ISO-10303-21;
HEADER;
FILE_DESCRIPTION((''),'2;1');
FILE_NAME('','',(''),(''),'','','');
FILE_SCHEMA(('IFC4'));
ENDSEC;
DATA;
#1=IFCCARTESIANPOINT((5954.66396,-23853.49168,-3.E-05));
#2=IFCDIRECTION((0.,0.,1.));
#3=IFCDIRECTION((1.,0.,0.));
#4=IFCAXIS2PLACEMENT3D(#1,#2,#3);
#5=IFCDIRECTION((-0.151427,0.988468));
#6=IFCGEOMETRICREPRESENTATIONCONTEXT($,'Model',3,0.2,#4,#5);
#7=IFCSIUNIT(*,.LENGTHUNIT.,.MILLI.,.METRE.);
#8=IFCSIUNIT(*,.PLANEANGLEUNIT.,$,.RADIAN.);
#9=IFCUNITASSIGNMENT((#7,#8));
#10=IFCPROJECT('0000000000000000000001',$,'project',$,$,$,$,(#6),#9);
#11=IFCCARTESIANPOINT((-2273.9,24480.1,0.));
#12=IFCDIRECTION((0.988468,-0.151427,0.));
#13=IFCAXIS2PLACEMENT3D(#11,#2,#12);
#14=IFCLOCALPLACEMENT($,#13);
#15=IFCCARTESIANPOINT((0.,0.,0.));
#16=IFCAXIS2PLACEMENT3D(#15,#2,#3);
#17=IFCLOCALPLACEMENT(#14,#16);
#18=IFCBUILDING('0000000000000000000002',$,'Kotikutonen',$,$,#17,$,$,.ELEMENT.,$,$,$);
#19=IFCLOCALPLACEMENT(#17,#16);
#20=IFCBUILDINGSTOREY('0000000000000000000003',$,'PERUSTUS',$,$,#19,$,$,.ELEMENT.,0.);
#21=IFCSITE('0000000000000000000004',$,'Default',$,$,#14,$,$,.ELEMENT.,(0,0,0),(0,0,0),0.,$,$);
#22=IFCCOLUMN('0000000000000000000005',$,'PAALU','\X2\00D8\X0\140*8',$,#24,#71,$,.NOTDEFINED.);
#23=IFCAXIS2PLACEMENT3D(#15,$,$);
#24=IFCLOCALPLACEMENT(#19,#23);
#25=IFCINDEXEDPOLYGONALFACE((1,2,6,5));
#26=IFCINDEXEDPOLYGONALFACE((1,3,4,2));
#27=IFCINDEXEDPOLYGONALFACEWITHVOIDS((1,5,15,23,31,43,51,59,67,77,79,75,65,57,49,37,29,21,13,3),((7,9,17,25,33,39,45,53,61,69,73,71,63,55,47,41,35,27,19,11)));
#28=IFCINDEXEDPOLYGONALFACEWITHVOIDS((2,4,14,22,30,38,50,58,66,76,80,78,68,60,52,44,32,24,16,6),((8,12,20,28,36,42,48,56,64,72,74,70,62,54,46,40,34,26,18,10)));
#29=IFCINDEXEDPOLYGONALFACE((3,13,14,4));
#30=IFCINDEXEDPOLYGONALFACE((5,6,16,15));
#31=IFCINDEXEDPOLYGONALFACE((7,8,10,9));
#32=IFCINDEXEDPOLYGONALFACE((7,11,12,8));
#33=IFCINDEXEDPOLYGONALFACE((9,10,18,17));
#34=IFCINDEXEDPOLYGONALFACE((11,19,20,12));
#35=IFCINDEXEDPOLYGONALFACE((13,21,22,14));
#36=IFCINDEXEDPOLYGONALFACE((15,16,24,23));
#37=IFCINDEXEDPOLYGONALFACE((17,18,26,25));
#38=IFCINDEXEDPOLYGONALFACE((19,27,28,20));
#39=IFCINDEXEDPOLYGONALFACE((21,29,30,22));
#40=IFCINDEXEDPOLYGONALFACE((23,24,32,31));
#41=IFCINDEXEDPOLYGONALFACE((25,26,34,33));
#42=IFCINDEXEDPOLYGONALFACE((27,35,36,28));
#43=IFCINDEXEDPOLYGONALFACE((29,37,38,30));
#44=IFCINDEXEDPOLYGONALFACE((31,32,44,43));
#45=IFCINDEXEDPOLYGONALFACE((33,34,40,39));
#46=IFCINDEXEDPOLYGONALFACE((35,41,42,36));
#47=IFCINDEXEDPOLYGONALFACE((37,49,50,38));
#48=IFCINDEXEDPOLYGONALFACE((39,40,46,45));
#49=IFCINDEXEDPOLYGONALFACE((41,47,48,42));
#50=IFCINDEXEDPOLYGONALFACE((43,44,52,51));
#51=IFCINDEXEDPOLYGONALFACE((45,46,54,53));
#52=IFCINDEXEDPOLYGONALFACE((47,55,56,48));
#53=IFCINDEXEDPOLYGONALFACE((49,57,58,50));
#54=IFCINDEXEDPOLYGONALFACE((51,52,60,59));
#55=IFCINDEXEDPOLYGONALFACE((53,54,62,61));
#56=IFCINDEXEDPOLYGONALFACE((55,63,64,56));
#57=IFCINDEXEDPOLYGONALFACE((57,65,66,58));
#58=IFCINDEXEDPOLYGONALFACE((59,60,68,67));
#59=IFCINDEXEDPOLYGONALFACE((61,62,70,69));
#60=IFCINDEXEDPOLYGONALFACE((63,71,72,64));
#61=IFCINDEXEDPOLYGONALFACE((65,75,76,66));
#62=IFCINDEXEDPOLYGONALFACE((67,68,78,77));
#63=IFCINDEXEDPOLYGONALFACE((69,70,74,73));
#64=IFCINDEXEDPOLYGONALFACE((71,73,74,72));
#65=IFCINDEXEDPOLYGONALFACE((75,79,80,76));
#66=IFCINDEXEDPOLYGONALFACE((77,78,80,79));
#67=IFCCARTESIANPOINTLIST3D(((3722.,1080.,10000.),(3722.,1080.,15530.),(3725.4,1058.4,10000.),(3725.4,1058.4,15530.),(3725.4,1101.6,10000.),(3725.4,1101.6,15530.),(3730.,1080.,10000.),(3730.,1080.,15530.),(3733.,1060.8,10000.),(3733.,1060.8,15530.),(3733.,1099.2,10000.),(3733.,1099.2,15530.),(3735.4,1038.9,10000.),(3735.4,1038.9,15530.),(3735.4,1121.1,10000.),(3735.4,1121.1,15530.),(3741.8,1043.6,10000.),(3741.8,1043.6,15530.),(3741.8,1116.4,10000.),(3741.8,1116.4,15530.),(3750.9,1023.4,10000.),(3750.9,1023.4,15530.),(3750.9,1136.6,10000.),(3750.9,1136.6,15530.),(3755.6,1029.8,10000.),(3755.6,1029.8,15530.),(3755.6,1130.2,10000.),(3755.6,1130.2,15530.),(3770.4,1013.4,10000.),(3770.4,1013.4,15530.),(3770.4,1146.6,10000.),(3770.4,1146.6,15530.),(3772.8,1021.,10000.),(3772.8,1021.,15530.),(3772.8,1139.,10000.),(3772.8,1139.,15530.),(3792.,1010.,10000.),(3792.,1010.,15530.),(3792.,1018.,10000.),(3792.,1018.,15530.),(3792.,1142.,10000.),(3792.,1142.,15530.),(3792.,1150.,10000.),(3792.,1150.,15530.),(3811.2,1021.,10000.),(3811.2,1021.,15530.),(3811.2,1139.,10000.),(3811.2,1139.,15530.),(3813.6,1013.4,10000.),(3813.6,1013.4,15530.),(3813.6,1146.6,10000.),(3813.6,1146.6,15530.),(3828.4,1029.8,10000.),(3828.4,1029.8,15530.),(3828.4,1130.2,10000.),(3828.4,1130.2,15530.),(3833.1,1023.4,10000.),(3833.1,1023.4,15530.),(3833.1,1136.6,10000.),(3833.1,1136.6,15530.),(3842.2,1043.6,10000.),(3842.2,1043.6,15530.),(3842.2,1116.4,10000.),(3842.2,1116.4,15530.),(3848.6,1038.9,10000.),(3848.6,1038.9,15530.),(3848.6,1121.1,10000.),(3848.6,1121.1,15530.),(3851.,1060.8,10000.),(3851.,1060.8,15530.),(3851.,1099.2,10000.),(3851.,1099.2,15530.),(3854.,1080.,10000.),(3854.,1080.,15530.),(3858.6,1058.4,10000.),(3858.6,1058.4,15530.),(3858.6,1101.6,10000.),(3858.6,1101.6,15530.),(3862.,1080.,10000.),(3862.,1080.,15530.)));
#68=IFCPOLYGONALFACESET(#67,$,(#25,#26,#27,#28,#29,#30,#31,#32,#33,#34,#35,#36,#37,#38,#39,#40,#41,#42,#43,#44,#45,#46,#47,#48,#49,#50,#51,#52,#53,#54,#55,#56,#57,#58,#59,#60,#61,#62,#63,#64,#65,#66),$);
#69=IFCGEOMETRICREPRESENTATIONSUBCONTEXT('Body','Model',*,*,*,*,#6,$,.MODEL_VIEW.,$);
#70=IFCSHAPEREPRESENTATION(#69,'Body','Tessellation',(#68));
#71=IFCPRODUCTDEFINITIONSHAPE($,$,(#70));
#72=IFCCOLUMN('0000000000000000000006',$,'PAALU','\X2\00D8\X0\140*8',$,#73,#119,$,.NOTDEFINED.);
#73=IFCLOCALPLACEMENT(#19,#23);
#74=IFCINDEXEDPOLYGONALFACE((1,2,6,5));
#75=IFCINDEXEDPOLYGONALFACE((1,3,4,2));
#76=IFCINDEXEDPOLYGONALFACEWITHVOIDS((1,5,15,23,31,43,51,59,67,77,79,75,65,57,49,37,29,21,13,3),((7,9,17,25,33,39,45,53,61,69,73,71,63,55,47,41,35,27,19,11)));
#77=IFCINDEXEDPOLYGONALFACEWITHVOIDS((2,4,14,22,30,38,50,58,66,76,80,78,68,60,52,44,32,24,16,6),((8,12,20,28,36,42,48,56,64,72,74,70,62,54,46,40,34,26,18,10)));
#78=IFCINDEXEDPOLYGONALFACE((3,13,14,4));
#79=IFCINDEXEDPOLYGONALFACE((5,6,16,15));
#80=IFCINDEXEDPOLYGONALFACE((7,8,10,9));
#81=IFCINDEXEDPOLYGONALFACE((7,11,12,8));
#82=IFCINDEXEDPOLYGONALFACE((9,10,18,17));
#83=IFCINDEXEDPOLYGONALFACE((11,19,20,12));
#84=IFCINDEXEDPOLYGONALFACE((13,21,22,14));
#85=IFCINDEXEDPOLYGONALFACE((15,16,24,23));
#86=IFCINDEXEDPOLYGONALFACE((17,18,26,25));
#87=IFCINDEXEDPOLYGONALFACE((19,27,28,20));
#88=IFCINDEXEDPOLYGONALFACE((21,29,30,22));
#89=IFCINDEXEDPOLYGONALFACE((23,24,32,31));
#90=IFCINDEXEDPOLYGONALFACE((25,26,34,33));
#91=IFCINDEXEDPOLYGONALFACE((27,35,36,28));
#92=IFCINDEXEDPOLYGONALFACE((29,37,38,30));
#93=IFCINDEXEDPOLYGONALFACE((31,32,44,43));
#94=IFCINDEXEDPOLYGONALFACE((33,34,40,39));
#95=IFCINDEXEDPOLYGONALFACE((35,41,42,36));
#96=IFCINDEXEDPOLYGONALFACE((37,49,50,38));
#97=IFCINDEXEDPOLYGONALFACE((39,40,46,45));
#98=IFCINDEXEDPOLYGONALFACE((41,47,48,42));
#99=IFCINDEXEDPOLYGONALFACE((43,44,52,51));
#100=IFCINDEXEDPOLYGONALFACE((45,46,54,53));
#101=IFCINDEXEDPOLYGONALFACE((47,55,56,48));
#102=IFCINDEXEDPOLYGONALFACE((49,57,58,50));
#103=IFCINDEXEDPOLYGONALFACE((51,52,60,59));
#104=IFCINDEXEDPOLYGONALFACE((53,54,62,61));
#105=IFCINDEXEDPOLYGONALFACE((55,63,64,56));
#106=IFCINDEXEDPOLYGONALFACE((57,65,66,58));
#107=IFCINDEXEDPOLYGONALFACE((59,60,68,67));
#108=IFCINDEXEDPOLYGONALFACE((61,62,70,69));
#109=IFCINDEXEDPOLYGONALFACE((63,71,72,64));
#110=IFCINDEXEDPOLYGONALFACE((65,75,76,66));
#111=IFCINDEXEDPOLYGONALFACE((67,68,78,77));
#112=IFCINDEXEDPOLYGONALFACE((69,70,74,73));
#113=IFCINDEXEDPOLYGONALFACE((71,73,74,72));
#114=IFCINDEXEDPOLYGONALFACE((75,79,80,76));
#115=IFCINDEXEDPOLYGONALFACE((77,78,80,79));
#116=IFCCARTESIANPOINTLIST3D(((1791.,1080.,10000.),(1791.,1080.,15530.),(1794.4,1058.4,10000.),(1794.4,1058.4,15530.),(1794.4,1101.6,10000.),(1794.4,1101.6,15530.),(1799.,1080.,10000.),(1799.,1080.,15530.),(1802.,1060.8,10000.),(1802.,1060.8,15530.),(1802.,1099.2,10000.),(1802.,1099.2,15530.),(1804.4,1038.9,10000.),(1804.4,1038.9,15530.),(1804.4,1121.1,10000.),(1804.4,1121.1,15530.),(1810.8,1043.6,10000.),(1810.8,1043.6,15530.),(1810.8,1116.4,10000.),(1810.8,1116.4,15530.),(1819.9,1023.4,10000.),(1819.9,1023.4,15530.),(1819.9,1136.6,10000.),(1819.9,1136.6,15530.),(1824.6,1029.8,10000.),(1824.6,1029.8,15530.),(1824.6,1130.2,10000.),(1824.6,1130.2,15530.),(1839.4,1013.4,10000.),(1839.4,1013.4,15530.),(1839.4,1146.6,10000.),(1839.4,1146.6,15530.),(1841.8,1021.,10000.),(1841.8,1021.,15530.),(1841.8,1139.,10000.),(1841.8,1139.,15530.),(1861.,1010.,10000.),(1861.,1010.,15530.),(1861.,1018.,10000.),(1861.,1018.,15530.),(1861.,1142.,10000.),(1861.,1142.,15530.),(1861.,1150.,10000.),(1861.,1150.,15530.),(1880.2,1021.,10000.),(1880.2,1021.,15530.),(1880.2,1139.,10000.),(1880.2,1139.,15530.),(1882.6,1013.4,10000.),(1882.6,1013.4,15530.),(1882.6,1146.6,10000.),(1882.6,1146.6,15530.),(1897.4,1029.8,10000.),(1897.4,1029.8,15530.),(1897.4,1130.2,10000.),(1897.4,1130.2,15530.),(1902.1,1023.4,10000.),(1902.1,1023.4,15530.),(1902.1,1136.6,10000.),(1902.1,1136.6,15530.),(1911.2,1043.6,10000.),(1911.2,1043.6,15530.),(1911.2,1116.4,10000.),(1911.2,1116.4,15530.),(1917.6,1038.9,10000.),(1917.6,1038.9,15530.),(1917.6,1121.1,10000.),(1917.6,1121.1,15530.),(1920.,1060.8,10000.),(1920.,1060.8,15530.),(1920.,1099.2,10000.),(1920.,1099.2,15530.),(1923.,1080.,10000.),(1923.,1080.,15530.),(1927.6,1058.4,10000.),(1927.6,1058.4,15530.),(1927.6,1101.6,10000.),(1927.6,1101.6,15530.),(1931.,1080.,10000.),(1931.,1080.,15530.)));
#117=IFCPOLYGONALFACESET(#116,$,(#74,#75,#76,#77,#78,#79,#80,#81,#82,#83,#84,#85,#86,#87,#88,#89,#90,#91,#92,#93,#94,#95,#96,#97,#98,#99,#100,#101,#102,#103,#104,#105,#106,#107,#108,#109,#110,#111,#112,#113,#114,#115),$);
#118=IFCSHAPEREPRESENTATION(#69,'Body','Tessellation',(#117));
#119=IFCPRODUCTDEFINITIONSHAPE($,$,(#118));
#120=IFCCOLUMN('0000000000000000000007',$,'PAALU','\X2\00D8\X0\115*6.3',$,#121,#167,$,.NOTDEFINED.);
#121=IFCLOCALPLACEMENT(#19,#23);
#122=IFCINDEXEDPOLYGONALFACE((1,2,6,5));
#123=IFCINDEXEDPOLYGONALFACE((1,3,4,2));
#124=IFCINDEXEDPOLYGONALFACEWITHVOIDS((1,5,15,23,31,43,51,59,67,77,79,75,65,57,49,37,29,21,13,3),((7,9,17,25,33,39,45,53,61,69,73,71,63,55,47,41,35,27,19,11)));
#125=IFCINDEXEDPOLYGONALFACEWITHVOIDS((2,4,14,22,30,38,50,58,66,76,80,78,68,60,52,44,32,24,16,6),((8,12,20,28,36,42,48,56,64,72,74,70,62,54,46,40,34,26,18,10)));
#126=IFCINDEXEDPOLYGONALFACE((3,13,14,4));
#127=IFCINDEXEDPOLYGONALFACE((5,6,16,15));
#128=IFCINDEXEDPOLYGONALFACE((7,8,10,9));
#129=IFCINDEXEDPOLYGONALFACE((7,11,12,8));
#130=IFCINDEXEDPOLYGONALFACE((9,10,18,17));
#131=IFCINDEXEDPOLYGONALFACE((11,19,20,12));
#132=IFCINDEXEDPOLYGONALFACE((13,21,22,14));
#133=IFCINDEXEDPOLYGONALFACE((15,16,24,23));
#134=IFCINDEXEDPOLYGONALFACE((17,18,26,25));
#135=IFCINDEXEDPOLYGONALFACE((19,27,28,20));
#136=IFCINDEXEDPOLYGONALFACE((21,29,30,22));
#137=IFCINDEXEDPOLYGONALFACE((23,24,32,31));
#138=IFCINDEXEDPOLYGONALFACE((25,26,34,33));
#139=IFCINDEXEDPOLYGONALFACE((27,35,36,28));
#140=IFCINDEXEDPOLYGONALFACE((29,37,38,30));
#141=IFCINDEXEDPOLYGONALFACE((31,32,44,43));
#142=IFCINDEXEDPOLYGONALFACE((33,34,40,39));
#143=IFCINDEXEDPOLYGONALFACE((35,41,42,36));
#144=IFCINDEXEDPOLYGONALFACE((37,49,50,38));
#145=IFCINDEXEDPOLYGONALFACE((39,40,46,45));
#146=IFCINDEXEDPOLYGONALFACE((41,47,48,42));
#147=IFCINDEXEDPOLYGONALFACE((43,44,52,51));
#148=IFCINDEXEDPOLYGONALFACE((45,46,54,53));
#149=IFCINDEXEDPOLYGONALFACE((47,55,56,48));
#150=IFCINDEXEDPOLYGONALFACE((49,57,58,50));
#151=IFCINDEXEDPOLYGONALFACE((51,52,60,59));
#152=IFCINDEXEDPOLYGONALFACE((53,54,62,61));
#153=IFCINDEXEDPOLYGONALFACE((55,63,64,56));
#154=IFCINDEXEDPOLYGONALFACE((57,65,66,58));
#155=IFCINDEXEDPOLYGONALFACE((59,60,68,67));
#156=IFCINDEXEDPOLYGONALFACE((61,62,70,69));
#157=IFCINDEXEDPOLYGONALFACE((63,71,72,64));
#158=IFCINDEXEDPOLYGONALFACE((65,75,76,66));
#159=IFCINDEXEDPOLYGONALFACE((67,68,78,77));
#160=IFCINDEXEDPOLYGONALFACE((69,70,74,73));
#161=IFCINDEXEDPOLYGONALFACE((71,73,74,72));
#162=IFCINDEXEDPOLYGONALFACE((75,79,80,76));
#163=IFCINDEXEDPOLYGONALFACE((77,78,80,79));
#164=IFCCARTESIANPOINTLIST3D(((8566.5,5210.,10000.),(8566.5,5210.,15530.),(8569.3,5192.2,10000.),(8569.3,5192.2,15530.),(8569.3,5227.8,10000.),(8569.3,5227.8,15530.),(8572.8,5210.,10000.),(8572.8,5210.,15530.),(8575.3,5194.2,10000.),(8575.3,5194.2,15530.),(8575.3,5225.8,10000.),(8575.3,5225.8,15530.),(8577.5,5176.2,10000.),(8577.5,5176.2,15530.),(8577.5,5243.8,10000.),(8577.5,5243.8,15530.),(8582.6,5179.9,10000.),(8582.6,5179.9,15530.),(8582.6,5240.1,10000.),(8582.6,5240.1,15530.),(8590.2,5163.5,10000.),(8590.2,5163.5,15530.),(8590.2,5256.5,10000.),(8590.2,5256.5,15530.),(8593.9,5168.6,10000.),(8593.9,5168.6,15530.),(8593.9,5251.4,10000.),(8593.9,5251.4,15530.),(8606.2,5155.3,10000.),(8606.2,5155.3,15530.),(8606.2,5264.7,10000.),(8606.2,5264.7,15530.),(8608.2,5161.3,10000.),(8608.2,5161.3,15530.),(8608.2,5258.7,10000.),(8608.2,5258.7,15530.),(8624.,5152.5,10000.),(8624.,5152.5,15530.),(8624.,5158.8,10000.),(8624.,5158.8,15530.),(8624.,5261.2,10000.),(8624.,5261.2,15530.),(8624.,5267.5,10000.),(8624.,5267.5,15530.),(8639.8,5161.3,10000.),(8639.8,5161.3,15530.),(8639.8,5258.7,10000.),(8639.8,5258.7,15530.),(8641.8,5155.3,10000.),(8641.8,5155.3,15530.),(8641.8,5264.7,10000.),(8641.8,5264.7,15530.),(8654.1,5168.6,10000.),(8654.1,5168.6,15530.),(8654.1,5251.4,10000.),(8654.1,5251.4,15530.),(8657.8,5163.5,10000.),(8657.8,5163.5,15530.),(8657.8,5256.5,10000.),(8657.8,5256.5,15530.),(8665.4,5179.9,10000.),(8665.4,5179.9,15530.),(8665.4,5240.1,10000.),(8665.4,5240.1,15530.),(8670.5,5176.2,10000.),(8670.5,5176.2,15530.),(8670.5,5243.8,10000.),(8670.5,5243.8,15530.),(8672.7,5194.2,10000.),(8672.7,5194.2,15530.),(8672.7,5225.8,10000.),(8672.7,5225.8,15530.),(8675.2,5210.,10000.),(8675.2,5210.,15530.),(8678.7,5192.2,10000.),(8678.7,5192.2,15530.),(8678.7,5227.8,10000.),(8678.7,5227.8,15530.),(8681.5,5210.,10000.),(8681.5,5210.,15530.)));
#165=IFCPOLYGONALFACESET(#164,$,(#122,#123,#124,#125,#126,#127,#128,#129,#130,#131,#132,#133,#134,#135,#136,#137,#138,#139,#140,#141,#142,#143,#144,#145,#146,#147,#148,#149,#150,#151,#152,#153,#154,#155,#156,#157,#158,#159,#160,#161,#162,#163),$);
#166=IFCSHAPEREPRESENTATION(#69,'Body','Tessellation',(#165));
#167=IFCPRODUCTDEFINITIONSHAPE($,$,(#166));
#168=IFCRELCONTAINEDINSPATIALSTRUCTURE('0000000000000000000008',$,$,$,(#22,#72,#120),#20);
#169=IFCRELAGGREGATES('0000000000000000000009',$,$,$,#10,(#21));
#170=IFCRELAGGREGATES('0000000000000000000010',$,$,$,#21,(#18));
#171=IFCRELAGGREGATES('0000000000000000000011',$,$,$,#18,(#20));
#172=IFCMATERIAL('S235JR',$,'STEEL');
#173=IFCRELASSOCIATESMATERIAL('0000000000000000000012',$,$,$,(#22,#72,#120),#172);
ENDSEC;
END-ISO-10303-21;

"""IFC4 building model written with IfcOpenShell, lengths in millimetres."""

from ifc_helpers import new_model, si_unit, direction, frame, origin_with_axes, place, context, subcontext, project, spatial, line, indexed_curve, outline, extrude, material, element, save


model = new_model("IFC4")

# Units and contexts
model_context = context("Model", 3, precision=0.2, world=frame((5954.66396, -23853.49168, -3e-05), z_axis=(0.0, 0.0, 1.0), x_axis=(1.0, 0.0, 0.0)), true_north=direction((-0.151427, 0.988468)))
body_context = subcontext(model_context, "Body", "Model", "MODEL_VIEW")
ifc_project = project(units=[si_unit("LENGTHUNIT", "METRE", prefix="MILLI"), si_unit("PLANEANGLEUNIT", "RADIAN")], contexts=[model_context])

# Site, building, storey
site_placement = place(None, frame((-2273.9, 24480.1, 0.0), z_axis=(0.0, 0.0, 1.0), x_axis=(0.988468, -0.151427, 0.0)))
site = spatial("IfcSite", under=ifc_project, at=site_placement, Name="Default", CompositionType="ELEMENT", RefLatitude=(0, 0, 0), RefLongitude=(0, 0, 0), RefElevation=0.0)
building_placement = place(site_placement, origin_with_axes())
building = spatial("IfcBuilding", under=site, at=building_placement, Name="Kotikutonen", CompositionType="ELEMENT")
storey_placement = place(building_placement, origin_with_axes())
storey = spatial("IfcBuildingStorey", under=building, at=storey_placement, Name="PERUSTUS", CompositionType="ELEMENT", Elevation=0.0)

# Columns
ifc_material = material(Name="S235JR", Category="STEEL")
for number, where, z_axis, x_axis, name in (
    (1, (3792.0, 1080.0, 10000.0), (-1.0, 0.0, 0.0), (0.0, 0.0, 1.0), "PAALU"),
    (2, (1861.0, 1080.0, 10000.0), (-1.0, 0.0, 0.0), (0.0, 0.0, 1.0), "PAALU"),
):
    element("IfcColumn", number, at=place(storey_placement, frame(where, z_axis=z_axis, x_axis=x_axis)), inside=storey, material=ifc_material, Name=name, Description="Ø140*8", PredefinedType="NOTDEFINED", context=body_context, shape_type="SolidModel", body=[
        extrude(outline(indexed_curve([(70.0, 0.0), (66.6, 21.6), (56.6, 41.1), (41.1, 56.6), (21.6, 66.6), (0.0, 70.0), (-21.6, 66.6), (-41.1, 56.6), (-56.6, 41.1), (-66.6, 21.6), (-70.0, 0.0), (-66.6, -21.6), (-56.6, -41.1), (-41.1, -56.6), (-21.6, -66.6), (0.0, -70.0), (21.6, -66.6), (41.1, -56.6), (56.6, -41.1), (66.6, -21.6)], segments=[line(1, 2, 3, 4, 5, 6, 7, 8, 9, 10, 11, 12, 13, 14, 15, 16, 17, 18, 19, 20, 1)]), holes=[indexed_curve([(62.0, 0.0), (59.0, -19.2), (50.2, -36.4), (36.4, -50.2), (19.2, -59.0), (0.0, -62.0), (-19.2, -59.0), (-36.4, -50.2), (-50.2, -36.4), (-59.0, -19.2), (-62.0, 0.0), (-59.0, 19.2), (-50.2, 36.4), (-36.4, 50.2), (-19.2, 59.0), (0.0, 62.0), (19.2, 59.0), (36.4, 50.2), (50.2, 36.4), (59.0, 19.2)], segments=[line(1, 2, 3, 4, 5, 6, 7, 8, 9, 10, 11, 12, 13, 14, 15, 16, 17, 18, 19, 20, 1)])]), frame((0.0, 0.0, 0.0), z_axis=(-1.0, 0.0, 0.0), x_axis=(0.0, 0.0, 1.0)), (0.0, 0.0, -1.0), 5530.0),
    ])
for number, where, z_axis, x_axis, name in (
    (3, (8624.0, 5210.0, 10000.0), (-1.0, 0.0, 0.0), (0.0, 0.0, 1.0), "PAALU"),
):
    element("IfcColumn", number, at=place(storey_placement, frame(where, z_axis=z_axis, x_axis=x_axis)), inside=storey, material=ifc_material, Name=name, Description="Ø115*6.3", PredefinedType="NOTDEFINED", context=body_context, shape_type="SolidModel", body=[
        extrude(outline(indexed_curve([(57.5, 0.0), (54.7, 17.8), (46.5, 33.8), (33.8, 46.5), (17.8, 54.7), (0.0, 57.5), (-17.8, 54.7), (-33.8, 46.5), (-46.5, 33.8), (-54.7, 17.8), (-57.5, 0.0), (-54.7, -17.8), (-46.5, -33.8), (-33.8, -46.5), (-17.8, -54.7), (0.0, -57.5), (17.8, -54.7), (33.8, -46.5), (46.5, -33.8), (54.7, -17.8)], segments=[line(1, 2, 3, 4, 5, 6, 7, 8, 9, 10, 11, 12, 13, 14, 15, 16, 17, 18, 19, 20, 1)]), holes=[indexed_curve([(51.2, 0.0), (48.7, -15.8), (41.4, -30.1), (30.1, -41.4), (15.8, -48.7), (0.0, -51.2), (-15.8, -48.7), (-30.1, -41.4), (-41.4, -30.1), (-48.7, -15.8), (-51.2, 0.0), (-48.7, 15.8), (-41.4, 30.1), (-30.1, 41.4), (-15.8, 48.7), (0.0, 51.2), (15.8, 48.7), (30.1, 41.4), (41.4, 30.1), (48.7, 15.8)], segments=[line(1, 2, 3, 4, 5, 6, 7, 8, 9, 10, 11, 12, 13, 14, 15, 16, 17, 18, 19, 20, 1)])]), frame((0.0, 0.0, 0.0), z_axis=(-1.0, 0.0, 0.0), x_axis=(0.0, 0.0, 1.0)), (0.0, 0.0, -1.0), 5530.0),
    ])

save(model, "model.ifc")
